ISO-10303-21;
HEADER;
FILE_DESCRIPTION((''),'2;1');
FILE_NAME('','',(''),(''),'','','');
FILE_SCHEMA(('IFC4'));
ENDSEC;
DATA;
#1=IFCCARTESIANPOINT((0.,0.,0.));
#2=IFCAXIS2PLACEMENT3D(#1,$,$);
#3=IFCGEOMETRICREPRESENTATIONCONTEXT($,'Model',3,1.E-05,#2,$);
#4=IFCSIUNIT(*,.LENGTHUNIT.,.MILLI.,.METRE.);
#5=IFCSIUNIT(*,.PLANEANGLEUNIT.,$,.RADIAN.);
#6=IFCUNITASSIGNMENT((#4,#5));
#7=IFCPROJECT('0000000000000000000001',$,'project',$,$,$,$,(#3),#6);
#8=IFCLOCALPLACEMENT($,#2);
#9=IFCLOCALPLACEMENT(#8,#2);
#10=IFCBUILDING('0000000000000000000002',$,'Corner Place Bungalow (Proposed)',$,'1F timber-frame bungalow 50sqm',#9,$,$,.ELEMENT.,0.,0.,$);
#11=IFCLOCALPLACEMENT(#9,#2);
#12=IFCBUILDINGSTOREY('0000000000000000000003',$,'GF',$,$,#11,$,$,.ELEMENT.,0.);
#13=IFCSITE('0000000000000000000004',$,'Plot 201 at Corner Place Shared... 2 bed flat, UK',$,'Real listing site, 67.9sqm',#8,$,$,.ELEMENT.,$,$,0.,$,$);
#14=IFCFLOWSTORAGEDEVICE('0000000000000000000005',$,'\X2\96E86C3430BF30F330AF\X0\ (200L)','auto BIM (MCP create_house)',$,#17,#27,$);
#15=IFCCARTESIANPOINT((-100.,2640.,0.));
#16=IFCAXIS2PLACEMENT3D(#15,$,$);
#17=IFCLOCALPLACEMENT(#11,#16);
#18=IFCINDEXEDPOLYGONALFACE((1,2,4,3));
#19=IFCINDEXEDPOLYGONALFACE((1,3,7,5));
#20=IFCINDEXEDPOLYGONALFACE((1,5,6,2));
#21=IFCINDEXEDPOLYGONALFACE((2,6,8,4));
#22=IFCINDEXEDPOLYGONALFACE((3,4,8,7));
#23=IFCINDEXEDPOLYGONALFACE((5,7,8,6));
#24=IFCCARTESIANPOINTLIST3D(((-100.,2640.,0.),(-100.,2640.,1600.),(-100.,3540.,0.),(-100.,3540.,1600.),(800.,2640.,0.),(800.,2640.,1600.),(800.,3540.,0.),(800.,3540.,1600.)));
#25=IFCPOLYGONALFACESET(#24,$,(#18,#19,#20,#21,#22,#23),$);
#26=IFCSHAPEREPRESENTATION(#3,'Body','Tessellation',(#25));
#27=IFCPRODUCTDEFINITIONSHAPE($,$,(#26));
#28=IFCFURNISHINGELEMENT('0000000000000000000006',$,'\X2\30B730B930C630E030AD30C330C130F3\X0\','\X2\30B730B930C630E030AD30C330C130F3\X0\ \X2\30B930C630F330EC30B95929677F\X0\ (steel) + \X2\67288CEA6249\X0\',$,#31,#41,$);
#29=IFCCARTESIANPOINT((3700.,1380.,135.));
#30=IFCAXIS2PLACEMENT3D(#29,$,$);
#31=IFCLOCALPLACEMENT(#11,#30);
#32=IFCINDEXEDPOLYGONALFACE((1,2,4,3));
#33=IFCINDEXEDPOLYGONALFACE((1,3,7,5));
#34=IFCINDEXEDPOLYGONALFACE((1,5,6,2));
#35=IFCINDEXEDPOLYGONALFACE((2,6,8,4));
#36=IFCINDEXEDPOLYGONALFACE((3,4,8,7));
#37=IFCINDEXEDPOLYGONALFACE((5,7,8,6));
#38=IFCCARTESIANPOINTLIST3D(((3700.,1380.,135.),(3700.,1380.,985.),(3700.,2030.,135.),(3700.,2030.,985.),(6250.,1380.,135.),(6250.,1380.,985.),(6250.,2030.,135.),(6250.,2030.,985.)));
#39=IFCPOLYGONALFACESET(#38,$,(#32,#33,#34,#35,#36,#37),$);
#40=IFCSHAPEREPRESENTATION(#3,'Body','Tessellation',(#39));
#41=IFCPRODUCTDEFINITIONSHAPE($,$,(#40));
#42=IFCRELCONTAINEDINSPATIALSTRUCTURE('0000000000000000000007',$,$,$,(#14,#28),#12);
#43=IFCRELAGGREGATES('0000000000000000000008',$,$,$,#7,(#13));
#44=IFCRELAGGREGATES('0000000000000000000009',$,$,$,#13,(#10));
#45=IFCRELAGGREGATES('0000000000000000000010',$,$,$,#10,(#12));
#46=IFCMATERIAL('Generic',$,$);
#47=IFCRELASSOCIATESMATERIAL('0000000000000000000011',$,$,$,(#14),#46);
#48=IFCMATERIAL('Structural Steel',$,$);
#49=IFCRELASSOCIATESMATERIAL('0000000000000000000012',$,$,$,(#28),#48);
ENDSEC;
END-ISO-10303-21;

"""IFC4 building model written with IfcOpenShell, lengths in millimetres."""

from ifc_helpers import new_model, si_unit, frame, frame_2d, origin, place, context, project, spatial, rectangle, extrude, material, element, save


model = new_model("IFC4")

# Units and contexts
model_context = context("Model", 3, precision=1e-05, world=origin())
ifc_project = project(units=[si_unit("LENGTHUNIT", "METRE", prefix="MILLI"), si_unit("PLANEANGLEUNIT", "RADIAN")], contexts=[model_context])

# Site, building, storey
site_placement = place(None, origin())
site = spatial("IfcSite", under=ifc_project, at=site_placement, Name="Plot 201 at Corner Place Shared... 2 bed flat, UK", ObjectType="Real listing site, 67.9sqm", CompositionType="ELEMENT", RefElevation=0.0)
building_placement = place(site_placement, origin())
building = spatial("IfcBuilding", under=site, at=building_placement, Name="Corner Place Bungalow (Proposed)", ObjectType="1F timber-frame bungalow 50sqm", CompositionType="ELEMENT", ElevationOfRefHeight=0.0, ElevationOfTerrain=0.0)
storey_placement = place(building_placement, origin())
storey = spatial("IfcBuildingStorey", under=building, at=storey_placement, Name="GF", CompositionType="ELEMENT", Elevation=0.0)

# Shared definitions
ifc_material_1 = material(Name="Generic")

# Flow storage device
flow_storage_device_placement = place(storey_placement, frame((-100.0, 2640.0, 0.0)))
element("IfcFlowStorageDevice", 1, at=flow_storage_device_placement, inside=storey, material=ifc_material_1, Name="雨水タンク (200L)", Description="auto BIM (MCP create_house)", context=model_context, shape_type="SweptSolid", body=[
    extrude(rectangle(XDim=900.0, YDim=900.0, at=frame_2d((450.0, 450.0))), frame((-100.0, 2640.0, 0.0)), (0.0, 0.0, 1.0), 1600.0),
])

# Furnishing element
ifc_material_2 = material(Name="Structural Steel")
furnishing_placement = place(storey_placement, frame((3700.0, 1380.0, 135.0)))
element("IfcFurnishingElement", 2, at=furnishing_placement, inside=storey, material=ifc_material_2, Name="システムキッチン", Description="システムキッチン ステンレス天板 (steel) + 木質扉", context=model_context, shape_type="SweptSolid", body=[
    extrude(rectangle(XDim=2550.0, YDim=650.0, at=frame_2d((1275.0, 325.0))), frame((3700.0, 1380.0, 135.0)), (0.0, 0.0, 1.0), 850.0),
])

save(model, "model.ifc")
